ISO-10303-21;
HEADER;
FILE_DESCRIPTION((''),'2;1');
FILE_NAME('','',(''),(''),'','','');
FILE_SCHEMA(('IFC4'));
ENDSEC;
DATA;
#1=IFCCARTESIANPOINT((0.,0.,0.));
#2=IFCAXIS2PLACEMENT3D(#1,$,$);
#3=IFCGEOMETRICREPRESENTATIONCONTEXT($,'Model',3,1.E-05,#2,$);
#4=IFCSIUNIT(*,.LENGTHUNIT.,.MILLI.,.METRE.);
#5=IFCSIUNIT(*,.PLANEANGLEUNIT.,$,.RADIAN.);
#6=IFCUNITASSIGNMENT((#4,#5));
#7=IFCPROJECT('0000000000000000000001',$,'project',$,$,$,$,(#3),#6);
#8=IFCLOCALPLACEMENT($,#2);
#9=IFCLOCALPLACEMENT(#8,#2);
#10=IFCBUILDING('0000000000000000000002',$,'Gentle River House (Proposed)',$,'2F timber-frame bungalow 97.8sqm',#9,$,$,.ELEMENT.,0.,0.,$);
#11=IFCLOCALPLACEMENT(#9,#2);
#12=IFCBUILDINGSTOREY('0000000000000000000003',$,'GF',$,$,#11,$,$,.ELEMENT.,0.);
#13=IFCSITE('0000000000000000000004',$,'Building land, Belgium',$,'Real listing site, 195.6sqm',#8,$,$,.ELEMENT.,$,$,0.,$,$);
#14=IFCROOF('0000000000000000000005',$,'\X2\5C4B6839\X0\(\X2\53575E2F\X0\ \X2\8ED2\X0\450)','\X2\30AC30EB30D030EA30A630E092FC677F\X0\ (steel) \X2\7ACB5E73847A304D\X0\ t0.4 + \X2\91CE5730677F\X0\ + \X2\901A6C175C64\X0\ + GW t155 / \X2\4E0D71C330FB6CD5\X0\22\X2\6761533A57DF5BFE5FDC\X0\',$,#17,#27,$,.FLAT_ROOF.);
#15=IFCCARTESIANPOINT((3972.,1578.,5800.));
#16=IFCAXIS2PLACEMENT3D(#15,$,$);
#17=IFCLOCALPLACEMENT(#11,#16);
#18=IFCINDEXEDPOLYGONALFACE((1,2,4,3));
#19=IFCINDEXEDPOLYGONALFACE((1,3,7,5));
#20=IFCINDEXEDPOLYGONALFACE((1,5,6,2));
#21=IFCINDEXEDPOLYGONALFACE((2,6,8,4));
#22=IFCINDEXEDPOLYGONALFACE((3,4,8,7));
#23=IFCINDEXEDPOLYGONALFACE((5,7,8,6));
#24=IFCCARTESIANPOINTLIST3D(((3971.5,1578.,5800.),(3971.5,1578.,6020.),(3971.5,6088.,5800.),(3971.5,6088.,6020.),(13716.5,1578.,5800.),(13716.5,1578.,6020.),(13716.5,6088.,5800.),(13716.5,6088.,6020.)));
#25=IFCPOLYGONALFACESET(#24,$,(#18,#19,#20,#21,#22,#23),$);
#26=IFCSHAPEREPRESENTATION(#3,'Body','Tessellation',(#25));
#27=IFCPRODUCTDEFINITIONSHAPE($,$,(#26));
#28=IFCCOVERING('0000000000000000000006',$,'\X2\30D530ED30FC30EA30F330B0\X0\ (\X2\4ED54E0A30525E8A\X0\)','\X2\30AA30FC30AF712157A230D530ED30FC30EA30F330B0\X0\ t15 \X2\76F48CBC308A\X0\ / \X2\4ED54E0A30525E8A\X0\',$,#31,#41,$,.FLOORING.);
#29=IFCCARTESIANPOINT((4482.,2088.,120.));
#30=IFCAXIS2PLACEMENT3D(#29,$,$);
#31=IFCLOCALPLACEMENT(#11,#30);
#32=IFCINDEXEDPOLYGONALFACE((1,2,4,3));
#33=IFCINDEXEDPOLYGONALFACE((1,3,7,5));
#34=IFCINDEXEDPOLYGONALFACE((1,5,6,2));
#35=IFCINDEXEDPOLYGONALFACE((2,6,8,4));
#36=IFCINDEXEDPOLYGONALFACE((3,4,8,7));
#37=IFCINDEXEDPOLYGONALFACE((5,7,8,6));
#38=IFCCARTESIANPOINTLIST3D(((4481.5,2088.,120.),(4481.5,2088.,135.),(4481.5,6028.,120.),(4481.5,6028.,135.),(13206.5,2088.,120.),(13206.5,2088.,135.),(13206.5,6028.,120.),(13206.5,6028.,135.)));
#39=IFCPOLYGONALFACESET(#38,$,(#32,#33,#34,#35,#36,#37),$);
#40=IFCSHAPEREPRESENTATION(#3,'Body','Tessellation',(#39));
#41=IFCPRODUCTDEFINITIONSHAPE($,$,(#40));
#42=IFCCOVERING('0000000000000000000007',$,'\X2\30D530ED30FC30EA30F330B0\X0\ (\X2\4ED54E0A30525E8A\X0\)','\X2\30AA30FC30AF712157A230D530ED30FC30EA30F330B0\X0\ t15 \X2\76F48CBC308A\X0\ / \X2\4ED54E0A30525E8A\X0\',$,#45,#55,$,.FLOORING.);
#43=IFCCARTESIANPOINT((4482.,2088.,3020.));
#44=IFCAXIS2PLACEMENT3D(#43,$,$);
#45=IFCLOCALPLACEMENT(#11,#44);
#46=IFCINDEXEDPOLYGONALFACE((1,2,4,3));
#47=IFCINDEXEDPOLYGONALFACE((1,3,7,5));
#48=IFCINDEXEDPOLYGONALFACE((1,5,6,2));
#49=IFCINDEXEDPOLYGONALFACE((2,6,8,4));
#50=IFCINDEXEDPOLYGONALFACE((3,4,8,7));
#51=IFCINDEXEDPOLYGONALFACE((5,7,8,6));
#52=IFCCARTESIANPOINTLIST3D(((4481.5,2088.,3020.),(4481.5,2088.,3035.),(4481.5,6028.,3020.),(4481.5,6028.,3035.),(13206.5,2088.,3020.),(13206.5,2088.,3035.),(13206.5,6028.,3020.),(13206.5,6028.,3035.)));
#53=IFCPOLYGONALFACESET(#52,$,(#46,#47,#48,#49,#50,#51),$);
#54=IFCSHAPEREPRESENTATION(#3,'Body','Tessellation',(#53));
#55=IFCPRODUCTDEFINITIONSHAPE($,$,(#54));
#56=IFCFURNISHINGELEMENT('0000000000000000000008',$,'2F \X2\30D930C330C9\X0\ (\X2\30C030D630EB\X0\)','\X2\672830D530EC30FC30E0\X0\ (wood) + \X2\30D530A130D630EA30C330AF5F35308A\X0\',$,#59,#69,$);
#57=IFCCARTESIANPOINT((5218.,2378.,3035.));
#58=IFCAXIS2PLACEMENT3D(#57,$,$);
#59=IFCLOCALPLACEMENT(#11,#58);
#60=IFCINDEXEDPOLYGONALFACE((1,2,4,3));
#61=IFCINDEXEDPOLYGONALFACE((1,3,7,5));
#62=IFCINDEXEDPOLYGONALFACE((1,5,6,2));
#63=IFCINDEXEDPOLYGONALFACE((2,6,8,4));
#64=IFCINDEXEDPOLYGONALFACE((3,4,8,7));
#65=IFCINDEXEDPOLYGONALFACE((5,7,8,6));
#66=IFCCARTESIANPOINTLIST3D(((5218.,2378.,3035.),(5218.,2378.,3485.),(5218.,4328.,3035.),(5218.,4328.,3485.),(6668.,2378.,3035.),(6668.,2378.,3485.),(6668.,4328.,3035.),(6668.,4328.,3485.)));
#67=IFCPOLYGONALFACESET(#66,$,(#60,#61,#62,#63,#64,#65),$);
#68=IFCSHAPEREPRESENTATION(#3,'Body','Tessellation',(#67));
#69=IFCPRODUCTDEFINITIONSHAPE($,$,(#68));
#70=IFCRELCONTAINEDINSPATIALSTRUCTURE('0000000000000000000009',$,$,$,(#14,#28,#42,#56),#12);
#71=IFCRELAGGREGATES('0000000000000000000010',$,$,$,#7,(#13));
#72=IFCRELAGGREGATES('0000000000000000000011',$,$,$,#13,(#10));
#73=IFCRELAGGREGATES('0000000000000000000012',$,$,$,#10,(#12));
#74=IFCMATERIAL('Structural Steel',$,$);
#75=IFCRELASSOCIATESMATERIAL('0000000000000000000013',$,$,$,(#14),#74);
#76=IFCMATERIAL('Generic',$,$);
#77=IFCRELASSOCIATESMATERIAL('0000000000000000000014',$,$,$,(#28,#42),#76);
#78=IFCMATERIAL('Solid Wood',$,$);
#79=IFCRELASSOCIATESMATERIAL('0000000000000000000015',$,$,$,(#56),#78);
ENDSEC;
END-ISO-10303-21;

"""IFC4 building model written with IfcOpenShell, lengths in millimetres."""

from ifc_helpers import new_model, si_unit, frame, frame_2d, origin, place, context, project, spatial, rectangle, extrude, material, element, save


model = new_model("IFC4")

# Units and contexts
model_context = context("Model", 3, precision=1e-05, world=origin())
ifc_project = project(units=[si_unit("LENGTHUNIT", "METRE", prefix="MILLI"), si_unit("PLANEANGLEUNIT", "RADIAN")], contexts=[model_context])

# Site, building, storey
site_placement = place(None, origin())
site = spatial("IfcSite", under=ifc_project, at=site_placement, Name="Building land, Belgium", ObjectType="Real listing site, 195.6sqm", CompositionType="ELEMENT", RefElevation=0.0)
building_placement = place(site_placement, origin())
building = spatial("IfcBuilding", under=site, at=building_placement, Name="Gentle River House (Proposed)", ObjectType="2F timber-frame bungalow 97.8sqm", CompositionType="ELEMENT", ElevationOfRefHeight=0.0, ElevationOfTerrain=0.0)
storey_placement = place(building_placement, origin())
storey = spatial("IfcBuildingStorey", under=building, at=storey_placement, Name="GF", CompositionType="ELEMENT", Elevation=0.0)

# Shared definitions
ifc_material_1 = material(Name="Solid Wood")

# Roof
ifc_material_2 = material(Name="Structural Steel")
for number, where, name in (
    (1, (3972.0, 1578.0, 5800.0), "屋根(南帯 軒450)"),
):
    element("IfcRoof", number, at=place(storey_placement, frame(where)), inside=storey, material=ifc_material_2, Name=name, Description="ガルバリウム鋼板 (steel) 立平葺き t0.4 + 野地板 + 通気層 + GW t155 / 不燃・法22条区域対応", PredefinedType="FLAT_ROOF", context=model_context, shape_type="SweptSolid", body=[
        extrude(rectangle(XDim=9745.0, YDim=4510.0, at=frame_2d((4872.0, 2255.0))), frame((3972.0, 1578.0, 5800.0)), (0.0, 0.0, 1.0), 220.0),
    ])

# Coverings
ifc_material_3 = material(Name="Generic")
covering_1_placement = place(storey_placement, frame((4482.0, 2088.0, 120.0)))
element("IfcCovering", 2, at=covering_1_placement, inside=storey, material=ifc_material_3, Name="フローリング (仕上げ床)", Description="オーク無垢フローリング t15 直貼り / 仕上げ床", PredefinedType="FLOORING", context=model_context, shape_type="SweptSolid", body=[
    extrude(rectangle(XDim=8725.0, YDim=3940.0, at=frame_2d((4362.0, 1970.0))), frame((4482.0, 2088.0, 120.0)), (0.0, 0.0, 1.0), 15.0),
])
covering_2_placement = place(storey_placement, frame((4482.0, 2088.0, 3020.0)))
element("IfcCovering", 3, at=covering_2_placement, inside=storey, material=ifc_material_3, Name="フローリング (仕上げ床)", Description="オーク無垢フローリング t15 直貼り / 仕上げ床", PredefinedType="FLOORING", context=model_context, shape_type="SweptSolid", body=[
    extrude(rectangle(XDim=8725.0, YDim=3940.0, at=frame_2d((4362.0, 1970.0))), frame((4482.0, 2088.0, 3020.0)), (0.0, 0.0, 1.0), 15.0),
])

# Furnishing element
furnishing_placement = place(storey_placement, frame((5218.0, 2378.0, 3035.0)))
element("IfcFurnishingElement", 4, at=furnishing_placement, inside=storey, material=ifc_material_1, Name="2F ベッド (ダブル)", Description="木フレーム (wood) + ファブリック張り", context=model_context, shape_type="SweptSolid", body=[
    extrude(rectangle(XDim=1450.0, YDim=1950.0, at=frame_2d((725.0, 975.0))), frame((5218.0, 2378.0, 3035.0)), (0.0, 0.0, 1.0), 450.0),
])

save(model, "model.ifc")
